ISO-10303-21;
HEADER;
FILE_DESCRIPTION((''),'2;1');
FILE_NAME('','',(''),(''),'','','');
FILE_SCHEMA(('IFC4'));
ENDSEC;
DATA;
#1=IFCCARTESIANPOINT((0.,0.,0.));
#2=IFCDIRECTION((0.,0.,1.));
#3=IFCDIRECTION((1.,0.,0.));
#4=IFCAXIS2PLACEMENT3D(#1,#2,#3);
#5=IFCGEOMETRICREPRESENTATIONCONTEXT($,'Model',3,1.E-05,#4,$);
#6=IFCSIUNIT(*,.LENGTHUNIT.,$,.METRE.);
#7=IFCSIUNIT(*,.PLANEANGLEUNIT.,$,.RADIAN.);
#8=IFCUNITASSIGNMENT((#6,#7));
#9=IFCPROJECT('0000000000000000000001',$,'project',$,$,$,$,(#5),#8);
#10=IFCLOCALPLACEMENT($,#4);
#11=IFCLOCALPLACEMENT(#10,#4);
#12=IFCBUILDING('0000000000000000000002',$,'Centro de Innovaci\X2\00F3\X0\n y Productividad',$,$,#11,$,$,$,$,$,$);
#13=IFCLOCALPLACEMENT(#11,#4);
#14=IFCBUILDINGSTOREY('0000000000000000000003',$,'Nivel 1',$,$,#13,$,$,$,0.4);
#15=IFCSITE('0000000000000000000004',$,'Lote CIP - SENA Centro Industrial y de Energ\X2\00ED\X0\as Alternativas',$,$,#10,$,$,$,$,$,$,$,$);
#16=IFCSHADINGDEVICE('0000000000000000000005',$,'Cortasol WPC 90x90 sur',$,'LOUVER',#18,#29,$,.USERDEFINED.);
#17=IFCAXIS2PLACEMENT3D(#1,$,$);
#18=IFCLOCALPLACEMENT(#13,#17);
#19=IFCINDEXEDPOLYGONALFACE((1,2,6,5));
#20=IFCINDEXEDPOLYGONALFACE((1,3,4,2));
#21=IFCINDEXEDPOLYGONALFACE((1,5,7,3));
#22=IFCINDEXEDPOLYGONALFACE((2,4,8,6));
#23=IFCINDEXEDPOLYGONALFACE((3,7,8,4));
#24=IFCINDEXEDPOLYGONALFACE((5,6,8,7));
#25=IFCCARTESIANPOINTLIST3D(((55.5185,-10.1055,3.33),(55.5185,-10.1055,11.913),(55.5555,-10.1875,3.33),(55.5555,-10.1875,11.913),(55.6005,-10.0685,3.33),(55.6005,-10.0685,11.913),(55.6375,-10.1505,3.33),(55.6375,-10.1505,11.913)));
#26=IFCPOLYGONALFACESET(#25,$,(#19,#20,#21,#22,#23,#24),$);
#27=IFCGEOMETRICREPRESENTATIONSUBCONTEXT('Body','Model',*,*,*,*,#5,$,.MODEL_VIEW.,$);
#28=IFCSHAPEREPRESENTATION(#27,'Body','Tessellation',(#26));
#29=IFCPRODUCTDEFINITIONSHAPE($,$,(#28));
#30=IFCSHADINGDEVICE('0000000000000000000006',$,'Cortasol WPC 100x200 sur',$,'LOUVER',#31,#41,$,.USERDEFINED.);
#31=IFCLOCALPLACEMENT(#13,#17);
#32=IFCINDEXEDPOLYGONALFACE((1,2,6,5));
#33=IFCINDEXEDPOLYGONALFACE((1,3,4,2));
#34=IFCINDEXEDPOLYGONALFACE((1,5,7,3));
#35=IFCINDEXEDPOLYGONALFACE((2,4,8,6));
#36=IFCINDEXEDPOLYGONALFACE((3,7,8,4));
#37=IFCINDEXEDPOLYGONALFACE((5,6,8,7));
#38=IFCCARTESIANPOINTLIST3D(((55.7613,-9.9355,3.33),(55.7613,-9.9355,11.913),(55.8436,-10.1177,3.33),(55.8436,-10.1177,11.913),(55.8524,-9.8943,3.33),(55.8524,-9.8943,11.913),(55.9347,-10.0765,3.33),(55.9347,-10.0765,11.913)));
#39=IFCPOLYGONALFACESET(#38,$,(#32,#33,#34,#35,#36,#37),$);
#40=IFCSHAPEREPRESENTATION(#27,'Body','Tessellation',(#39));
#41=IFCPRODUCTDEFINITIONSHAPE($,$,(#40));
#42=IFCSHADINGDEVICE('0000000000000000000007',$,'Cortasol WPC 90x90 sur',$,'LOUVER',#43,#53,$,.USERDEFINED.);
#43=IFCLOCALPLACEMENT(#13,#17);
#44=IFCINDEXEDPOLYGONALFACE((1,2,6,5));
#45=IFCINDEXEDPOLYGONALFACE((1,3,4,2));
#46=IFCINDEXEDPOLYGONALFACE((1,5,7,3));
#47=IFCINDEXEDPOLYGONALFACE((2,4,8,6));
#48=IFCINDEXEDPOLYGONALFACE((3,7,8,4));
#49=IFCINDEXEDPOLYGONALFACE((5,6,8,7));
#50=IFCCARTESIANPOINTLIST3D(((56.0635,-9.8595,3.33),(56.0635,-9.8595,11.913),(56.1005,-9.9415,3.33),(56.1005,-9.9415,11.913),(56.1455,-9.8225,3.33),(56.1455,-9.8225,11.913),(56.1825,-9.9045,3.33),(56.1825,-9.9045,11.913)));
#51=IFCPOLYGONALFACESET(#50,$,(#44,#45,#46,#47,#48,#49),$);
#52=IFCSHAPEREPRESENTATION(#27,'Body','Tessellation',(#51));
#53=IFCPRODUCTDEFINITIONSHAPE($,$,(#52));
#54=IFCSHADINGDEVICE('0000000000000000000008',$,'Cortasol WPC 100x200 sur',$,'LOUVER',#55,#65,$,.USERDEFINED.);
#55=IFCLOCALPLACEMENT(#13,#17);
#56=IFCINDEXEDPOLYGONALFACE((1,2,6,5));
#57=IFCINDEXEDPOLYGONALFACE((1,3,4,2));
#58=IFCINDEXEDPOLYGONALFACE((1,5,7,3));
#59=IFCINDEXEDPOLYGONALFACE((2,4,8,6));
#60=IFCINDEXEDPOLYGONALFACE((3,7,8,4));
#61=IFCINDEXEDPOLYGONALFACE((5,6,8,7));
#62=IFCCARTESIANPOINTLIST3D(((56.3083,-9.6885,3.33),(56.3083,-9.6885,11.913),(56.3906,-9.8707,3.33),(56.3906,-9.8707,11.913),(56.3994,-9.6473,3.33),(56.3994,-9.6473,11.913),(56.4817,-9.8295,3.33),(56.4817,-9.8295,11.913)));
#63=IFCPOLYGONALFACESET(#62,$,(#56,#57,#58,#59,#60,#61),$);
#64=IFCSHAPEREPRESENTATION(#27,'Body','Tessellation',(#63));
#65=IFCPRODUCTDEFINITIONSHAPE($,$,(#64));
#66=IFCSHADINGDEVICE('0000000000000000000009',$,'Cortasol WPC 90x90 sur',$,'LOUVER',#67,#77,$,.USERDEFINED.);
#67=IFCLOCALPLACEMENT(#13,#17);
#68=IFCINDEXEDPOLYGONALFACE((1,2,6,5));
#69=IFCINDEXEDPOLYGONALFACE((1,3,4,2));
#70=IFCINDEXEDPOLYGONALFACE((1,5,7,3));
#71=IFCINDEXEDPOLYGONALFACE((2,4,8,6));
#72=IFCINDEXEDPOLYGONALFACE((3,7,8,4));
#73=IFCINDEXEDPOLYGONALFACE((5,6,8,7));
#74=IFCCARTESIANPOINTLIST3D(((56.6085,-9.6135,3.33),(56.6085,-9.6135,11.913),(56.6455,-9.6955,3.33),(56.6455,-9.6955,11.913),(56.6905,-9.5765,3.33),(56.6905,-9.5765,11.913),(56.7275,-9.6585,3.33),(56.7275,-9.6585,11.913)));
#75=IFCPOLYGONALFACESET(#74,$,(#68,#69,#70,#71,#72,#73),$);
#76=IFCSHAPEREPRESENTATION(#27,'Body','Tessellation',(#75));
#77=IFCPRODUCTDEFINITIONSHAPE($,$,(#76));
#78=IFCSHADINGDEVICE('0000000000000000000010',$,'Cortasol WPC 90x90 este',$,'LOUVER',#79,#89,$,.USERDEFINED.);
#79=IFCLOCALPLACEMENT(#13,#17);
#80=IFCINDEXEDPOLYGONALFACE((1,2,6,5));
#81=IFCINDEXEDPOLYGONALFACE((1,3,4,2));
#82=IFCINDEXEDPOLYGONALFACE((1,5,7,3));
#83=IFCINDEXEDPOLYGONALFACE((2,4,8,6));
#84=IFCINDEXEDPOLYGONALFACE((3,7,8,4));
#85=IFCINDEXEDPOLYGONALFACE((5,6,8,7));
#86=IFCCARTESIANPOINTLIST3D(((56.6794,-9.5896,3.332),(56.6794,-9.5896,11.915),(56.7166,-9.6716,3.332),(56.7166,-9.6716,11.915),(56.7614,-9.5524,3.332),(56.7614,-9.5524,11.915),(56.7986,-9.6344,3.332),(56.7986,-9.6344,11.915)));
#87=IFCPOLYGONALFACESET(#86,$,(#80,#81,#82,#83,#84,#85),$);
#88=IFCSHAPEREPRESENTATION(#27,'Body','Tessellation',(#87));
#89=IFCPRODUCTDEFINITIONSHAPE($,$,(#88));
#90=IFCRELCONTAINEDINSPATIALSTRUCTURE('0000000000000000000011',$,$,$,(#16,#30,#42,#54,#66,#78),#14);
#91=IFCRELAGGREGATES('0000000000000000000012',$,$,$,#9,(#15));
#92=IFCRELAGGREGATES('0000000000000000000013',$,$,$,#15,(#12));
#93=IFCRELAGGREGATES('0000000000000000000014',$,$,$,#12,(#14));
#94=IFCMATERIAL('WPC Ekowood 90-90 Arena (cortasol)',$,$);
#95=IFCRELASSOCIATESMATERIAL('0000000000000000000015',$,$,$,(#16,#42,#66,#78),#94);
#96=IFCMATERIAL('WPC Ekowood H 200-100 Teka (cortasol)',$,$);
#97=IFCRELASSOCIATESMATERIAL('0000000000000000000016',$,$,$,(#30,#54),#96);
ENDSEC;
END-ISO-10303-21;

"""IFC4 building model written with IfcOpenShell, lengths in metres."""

from ifc_helpers import new_model, si_unit, frame, origin_with_axes, place, context, subcontext, project, spatial, polyline, outline, extrude, material, element, save


model = new_model("IFC4")

# Units and contexts
model_context = context("Model", 3, precision=1e-05, world=origin_with_axes())
body_context = subcontext(model_context, "Body", "Model", "MODEL_VIEW")
ifc_project = project(units=[si_unit("LENGTHUNIT", "METRE"), si_unit("PLANEANGLEUNIT", "RADIAN")], contexts=[model_context])

# Site, building, storey
site_placement = place(None, origin_with_axes())
site = spatial("IfcSite", under=ifc_project, at=site_placement, Name="Lote CIP - SENA Centro Industrial y de Energías Alternativas")
building_placement = place(site_placement, origin_with_axes())
building = spatial("IfcBuilding", under=site, at=building_placement, Name="Centro de Innovación y Productividad")
storey_placement = place(building_placement, origin_with_axes())
storey = spatial("IfcBuildingStorey", under=building, at=storey_placement, Name="Nivel 1", Elevation=0.4)

# Shading devices
ifc_material_1 = material(Name="WPC Ekowood H 200-100 Teka (cortasol)")
ifc_material_2 = material(Name="WPC Ekowood 90-90 Arena (cortasol)")
shading_device_1_placement = place(storey_placement, origin_with_axes())
element("IfcShadingDevice", 1, at=shading_device_1_placement, inside=storey, material=ifc_material_2, Name="Cortasol WPC 90x90 sur", ObjectType="LOUVER", PredefinedType="USERDEFINED", context=body_context, shape_type="SweptSolid", body=[
    extrude(outline(polyline([(55.5555, -10.1875), (55.5185, -10.1055), (55.6005, -10.0685), (55.6375, -10.1505), (55.5555, -10.1875)])), frame((0.0, 0.0, 3.33)), (0.0, 0.0, 1.0), 8.583),
])
shading_device_2_placement = place(storey_placement, origin_with_axes())
element("IfcShadingDevice", 2, at=shading_device_2_placement, inside=storey, material=ifc_material_1, Name="Cortasol WPC 100x200 sur", ObjectType="LOUVER", PredefinedType="USERDEFINED", context=body_context, shape_type="SweptSolid", body=[
    extrude(outline(polyline([(55.8436, -10.1177), (55.7613, -9.9355), (55.8524, -9.8943), (55.9347, -10.0765), (55.8436, -10.1177)])), frame((0.0, 0.0, 3.33)), (0.0, 0.0, 1.0), 8.583),
])
shading_device_3_placement = place(storey_placement, origin_with_axes())
element("IfcShadingDevice", 3, at=shading_device_3_placement, inside=storey, material=ifc_material_2, Name="Cortasol WPC 90x90 sur", ObjectType="LOUVER", PredefinedType="USERDEFINED", context=body_context, shape_type="SweptSolid", body=[
    extrude(outline(polyline([(56.1005, -9.9415), (56.0635, -9.8595), (56.1455, -9.8225), (56.1825, -9.9045), (56.1005, -9.9415)])), frame((0.0, 0.0, 3.33)), (0.0, 0.0, 1.0), 8.583),
])
shading_device_4_placement = place(storey_placement, origin_with_axes())
element("IfcShadingDevice", 4, at=shading_device_4_placement, inside=storey, material=ifc_material_1, Name="Cortasol WPC 100x200 sur", ObjectType="LOUVER", PredefinedType="USERDEFINED", context=body_context, shape_type="SweptSolid", body=[
    extrude(outline(polyline([(56.3906, -9.8707), (56.3083, -9.6885), (56.3994, -9.6473), (56.4817, -9.8295), (56.3906, -9.8707)])), frame((0.0, 0.0, 3.33)), (0.0, 0.0, 1.0), 8.583),
])
shading_device_5_placement = place(storey_placement, origin_with_axes())
element("IfcShadingDevice", 5, at=shading_device_5_placement, inside=storey, material=ifc_material_2, Name="Cortasol WPC 90x90 sur", ObjectType="LOUVER", PredefinedType="USERDEFINED", context=body_context, shape_type="SweptSolid", body=[
    extrude(outline(polyline([(56.6455, -9.6955), (56.6085, -9.6135), (56.6905, -9.5765), (56.7275, -9.6585), (56.6455, -9.6955)])), frame((0.0, 0.0, 3.33)), (0.0, 0.0, 1.0), 8.583),
])
shading_device_6_placement = place(storey_placement, origin_with_axes())
element("IfcShadingDevice", 6, at=shading_device_6_placement, inside=storey, material=ifc_material_2, Name="Cortasol WPC 90x90 este", ObjectType="LOUVER", PredefinedType="USERDEFINED", context=body_context, shape_type="SweptSolid", body=[
    extrude(outline(polyline([(56.6794, -9.5896), (56.7614, -9.5524), (56.7986, -9.6344), (56.7166, -9.6716), (56.6794, -9.5896)])), frame((0.0, 0.0, 3.332)), (0.0, 0.0, 1.0), 8.583),
])

save(model, "model.ifc")
